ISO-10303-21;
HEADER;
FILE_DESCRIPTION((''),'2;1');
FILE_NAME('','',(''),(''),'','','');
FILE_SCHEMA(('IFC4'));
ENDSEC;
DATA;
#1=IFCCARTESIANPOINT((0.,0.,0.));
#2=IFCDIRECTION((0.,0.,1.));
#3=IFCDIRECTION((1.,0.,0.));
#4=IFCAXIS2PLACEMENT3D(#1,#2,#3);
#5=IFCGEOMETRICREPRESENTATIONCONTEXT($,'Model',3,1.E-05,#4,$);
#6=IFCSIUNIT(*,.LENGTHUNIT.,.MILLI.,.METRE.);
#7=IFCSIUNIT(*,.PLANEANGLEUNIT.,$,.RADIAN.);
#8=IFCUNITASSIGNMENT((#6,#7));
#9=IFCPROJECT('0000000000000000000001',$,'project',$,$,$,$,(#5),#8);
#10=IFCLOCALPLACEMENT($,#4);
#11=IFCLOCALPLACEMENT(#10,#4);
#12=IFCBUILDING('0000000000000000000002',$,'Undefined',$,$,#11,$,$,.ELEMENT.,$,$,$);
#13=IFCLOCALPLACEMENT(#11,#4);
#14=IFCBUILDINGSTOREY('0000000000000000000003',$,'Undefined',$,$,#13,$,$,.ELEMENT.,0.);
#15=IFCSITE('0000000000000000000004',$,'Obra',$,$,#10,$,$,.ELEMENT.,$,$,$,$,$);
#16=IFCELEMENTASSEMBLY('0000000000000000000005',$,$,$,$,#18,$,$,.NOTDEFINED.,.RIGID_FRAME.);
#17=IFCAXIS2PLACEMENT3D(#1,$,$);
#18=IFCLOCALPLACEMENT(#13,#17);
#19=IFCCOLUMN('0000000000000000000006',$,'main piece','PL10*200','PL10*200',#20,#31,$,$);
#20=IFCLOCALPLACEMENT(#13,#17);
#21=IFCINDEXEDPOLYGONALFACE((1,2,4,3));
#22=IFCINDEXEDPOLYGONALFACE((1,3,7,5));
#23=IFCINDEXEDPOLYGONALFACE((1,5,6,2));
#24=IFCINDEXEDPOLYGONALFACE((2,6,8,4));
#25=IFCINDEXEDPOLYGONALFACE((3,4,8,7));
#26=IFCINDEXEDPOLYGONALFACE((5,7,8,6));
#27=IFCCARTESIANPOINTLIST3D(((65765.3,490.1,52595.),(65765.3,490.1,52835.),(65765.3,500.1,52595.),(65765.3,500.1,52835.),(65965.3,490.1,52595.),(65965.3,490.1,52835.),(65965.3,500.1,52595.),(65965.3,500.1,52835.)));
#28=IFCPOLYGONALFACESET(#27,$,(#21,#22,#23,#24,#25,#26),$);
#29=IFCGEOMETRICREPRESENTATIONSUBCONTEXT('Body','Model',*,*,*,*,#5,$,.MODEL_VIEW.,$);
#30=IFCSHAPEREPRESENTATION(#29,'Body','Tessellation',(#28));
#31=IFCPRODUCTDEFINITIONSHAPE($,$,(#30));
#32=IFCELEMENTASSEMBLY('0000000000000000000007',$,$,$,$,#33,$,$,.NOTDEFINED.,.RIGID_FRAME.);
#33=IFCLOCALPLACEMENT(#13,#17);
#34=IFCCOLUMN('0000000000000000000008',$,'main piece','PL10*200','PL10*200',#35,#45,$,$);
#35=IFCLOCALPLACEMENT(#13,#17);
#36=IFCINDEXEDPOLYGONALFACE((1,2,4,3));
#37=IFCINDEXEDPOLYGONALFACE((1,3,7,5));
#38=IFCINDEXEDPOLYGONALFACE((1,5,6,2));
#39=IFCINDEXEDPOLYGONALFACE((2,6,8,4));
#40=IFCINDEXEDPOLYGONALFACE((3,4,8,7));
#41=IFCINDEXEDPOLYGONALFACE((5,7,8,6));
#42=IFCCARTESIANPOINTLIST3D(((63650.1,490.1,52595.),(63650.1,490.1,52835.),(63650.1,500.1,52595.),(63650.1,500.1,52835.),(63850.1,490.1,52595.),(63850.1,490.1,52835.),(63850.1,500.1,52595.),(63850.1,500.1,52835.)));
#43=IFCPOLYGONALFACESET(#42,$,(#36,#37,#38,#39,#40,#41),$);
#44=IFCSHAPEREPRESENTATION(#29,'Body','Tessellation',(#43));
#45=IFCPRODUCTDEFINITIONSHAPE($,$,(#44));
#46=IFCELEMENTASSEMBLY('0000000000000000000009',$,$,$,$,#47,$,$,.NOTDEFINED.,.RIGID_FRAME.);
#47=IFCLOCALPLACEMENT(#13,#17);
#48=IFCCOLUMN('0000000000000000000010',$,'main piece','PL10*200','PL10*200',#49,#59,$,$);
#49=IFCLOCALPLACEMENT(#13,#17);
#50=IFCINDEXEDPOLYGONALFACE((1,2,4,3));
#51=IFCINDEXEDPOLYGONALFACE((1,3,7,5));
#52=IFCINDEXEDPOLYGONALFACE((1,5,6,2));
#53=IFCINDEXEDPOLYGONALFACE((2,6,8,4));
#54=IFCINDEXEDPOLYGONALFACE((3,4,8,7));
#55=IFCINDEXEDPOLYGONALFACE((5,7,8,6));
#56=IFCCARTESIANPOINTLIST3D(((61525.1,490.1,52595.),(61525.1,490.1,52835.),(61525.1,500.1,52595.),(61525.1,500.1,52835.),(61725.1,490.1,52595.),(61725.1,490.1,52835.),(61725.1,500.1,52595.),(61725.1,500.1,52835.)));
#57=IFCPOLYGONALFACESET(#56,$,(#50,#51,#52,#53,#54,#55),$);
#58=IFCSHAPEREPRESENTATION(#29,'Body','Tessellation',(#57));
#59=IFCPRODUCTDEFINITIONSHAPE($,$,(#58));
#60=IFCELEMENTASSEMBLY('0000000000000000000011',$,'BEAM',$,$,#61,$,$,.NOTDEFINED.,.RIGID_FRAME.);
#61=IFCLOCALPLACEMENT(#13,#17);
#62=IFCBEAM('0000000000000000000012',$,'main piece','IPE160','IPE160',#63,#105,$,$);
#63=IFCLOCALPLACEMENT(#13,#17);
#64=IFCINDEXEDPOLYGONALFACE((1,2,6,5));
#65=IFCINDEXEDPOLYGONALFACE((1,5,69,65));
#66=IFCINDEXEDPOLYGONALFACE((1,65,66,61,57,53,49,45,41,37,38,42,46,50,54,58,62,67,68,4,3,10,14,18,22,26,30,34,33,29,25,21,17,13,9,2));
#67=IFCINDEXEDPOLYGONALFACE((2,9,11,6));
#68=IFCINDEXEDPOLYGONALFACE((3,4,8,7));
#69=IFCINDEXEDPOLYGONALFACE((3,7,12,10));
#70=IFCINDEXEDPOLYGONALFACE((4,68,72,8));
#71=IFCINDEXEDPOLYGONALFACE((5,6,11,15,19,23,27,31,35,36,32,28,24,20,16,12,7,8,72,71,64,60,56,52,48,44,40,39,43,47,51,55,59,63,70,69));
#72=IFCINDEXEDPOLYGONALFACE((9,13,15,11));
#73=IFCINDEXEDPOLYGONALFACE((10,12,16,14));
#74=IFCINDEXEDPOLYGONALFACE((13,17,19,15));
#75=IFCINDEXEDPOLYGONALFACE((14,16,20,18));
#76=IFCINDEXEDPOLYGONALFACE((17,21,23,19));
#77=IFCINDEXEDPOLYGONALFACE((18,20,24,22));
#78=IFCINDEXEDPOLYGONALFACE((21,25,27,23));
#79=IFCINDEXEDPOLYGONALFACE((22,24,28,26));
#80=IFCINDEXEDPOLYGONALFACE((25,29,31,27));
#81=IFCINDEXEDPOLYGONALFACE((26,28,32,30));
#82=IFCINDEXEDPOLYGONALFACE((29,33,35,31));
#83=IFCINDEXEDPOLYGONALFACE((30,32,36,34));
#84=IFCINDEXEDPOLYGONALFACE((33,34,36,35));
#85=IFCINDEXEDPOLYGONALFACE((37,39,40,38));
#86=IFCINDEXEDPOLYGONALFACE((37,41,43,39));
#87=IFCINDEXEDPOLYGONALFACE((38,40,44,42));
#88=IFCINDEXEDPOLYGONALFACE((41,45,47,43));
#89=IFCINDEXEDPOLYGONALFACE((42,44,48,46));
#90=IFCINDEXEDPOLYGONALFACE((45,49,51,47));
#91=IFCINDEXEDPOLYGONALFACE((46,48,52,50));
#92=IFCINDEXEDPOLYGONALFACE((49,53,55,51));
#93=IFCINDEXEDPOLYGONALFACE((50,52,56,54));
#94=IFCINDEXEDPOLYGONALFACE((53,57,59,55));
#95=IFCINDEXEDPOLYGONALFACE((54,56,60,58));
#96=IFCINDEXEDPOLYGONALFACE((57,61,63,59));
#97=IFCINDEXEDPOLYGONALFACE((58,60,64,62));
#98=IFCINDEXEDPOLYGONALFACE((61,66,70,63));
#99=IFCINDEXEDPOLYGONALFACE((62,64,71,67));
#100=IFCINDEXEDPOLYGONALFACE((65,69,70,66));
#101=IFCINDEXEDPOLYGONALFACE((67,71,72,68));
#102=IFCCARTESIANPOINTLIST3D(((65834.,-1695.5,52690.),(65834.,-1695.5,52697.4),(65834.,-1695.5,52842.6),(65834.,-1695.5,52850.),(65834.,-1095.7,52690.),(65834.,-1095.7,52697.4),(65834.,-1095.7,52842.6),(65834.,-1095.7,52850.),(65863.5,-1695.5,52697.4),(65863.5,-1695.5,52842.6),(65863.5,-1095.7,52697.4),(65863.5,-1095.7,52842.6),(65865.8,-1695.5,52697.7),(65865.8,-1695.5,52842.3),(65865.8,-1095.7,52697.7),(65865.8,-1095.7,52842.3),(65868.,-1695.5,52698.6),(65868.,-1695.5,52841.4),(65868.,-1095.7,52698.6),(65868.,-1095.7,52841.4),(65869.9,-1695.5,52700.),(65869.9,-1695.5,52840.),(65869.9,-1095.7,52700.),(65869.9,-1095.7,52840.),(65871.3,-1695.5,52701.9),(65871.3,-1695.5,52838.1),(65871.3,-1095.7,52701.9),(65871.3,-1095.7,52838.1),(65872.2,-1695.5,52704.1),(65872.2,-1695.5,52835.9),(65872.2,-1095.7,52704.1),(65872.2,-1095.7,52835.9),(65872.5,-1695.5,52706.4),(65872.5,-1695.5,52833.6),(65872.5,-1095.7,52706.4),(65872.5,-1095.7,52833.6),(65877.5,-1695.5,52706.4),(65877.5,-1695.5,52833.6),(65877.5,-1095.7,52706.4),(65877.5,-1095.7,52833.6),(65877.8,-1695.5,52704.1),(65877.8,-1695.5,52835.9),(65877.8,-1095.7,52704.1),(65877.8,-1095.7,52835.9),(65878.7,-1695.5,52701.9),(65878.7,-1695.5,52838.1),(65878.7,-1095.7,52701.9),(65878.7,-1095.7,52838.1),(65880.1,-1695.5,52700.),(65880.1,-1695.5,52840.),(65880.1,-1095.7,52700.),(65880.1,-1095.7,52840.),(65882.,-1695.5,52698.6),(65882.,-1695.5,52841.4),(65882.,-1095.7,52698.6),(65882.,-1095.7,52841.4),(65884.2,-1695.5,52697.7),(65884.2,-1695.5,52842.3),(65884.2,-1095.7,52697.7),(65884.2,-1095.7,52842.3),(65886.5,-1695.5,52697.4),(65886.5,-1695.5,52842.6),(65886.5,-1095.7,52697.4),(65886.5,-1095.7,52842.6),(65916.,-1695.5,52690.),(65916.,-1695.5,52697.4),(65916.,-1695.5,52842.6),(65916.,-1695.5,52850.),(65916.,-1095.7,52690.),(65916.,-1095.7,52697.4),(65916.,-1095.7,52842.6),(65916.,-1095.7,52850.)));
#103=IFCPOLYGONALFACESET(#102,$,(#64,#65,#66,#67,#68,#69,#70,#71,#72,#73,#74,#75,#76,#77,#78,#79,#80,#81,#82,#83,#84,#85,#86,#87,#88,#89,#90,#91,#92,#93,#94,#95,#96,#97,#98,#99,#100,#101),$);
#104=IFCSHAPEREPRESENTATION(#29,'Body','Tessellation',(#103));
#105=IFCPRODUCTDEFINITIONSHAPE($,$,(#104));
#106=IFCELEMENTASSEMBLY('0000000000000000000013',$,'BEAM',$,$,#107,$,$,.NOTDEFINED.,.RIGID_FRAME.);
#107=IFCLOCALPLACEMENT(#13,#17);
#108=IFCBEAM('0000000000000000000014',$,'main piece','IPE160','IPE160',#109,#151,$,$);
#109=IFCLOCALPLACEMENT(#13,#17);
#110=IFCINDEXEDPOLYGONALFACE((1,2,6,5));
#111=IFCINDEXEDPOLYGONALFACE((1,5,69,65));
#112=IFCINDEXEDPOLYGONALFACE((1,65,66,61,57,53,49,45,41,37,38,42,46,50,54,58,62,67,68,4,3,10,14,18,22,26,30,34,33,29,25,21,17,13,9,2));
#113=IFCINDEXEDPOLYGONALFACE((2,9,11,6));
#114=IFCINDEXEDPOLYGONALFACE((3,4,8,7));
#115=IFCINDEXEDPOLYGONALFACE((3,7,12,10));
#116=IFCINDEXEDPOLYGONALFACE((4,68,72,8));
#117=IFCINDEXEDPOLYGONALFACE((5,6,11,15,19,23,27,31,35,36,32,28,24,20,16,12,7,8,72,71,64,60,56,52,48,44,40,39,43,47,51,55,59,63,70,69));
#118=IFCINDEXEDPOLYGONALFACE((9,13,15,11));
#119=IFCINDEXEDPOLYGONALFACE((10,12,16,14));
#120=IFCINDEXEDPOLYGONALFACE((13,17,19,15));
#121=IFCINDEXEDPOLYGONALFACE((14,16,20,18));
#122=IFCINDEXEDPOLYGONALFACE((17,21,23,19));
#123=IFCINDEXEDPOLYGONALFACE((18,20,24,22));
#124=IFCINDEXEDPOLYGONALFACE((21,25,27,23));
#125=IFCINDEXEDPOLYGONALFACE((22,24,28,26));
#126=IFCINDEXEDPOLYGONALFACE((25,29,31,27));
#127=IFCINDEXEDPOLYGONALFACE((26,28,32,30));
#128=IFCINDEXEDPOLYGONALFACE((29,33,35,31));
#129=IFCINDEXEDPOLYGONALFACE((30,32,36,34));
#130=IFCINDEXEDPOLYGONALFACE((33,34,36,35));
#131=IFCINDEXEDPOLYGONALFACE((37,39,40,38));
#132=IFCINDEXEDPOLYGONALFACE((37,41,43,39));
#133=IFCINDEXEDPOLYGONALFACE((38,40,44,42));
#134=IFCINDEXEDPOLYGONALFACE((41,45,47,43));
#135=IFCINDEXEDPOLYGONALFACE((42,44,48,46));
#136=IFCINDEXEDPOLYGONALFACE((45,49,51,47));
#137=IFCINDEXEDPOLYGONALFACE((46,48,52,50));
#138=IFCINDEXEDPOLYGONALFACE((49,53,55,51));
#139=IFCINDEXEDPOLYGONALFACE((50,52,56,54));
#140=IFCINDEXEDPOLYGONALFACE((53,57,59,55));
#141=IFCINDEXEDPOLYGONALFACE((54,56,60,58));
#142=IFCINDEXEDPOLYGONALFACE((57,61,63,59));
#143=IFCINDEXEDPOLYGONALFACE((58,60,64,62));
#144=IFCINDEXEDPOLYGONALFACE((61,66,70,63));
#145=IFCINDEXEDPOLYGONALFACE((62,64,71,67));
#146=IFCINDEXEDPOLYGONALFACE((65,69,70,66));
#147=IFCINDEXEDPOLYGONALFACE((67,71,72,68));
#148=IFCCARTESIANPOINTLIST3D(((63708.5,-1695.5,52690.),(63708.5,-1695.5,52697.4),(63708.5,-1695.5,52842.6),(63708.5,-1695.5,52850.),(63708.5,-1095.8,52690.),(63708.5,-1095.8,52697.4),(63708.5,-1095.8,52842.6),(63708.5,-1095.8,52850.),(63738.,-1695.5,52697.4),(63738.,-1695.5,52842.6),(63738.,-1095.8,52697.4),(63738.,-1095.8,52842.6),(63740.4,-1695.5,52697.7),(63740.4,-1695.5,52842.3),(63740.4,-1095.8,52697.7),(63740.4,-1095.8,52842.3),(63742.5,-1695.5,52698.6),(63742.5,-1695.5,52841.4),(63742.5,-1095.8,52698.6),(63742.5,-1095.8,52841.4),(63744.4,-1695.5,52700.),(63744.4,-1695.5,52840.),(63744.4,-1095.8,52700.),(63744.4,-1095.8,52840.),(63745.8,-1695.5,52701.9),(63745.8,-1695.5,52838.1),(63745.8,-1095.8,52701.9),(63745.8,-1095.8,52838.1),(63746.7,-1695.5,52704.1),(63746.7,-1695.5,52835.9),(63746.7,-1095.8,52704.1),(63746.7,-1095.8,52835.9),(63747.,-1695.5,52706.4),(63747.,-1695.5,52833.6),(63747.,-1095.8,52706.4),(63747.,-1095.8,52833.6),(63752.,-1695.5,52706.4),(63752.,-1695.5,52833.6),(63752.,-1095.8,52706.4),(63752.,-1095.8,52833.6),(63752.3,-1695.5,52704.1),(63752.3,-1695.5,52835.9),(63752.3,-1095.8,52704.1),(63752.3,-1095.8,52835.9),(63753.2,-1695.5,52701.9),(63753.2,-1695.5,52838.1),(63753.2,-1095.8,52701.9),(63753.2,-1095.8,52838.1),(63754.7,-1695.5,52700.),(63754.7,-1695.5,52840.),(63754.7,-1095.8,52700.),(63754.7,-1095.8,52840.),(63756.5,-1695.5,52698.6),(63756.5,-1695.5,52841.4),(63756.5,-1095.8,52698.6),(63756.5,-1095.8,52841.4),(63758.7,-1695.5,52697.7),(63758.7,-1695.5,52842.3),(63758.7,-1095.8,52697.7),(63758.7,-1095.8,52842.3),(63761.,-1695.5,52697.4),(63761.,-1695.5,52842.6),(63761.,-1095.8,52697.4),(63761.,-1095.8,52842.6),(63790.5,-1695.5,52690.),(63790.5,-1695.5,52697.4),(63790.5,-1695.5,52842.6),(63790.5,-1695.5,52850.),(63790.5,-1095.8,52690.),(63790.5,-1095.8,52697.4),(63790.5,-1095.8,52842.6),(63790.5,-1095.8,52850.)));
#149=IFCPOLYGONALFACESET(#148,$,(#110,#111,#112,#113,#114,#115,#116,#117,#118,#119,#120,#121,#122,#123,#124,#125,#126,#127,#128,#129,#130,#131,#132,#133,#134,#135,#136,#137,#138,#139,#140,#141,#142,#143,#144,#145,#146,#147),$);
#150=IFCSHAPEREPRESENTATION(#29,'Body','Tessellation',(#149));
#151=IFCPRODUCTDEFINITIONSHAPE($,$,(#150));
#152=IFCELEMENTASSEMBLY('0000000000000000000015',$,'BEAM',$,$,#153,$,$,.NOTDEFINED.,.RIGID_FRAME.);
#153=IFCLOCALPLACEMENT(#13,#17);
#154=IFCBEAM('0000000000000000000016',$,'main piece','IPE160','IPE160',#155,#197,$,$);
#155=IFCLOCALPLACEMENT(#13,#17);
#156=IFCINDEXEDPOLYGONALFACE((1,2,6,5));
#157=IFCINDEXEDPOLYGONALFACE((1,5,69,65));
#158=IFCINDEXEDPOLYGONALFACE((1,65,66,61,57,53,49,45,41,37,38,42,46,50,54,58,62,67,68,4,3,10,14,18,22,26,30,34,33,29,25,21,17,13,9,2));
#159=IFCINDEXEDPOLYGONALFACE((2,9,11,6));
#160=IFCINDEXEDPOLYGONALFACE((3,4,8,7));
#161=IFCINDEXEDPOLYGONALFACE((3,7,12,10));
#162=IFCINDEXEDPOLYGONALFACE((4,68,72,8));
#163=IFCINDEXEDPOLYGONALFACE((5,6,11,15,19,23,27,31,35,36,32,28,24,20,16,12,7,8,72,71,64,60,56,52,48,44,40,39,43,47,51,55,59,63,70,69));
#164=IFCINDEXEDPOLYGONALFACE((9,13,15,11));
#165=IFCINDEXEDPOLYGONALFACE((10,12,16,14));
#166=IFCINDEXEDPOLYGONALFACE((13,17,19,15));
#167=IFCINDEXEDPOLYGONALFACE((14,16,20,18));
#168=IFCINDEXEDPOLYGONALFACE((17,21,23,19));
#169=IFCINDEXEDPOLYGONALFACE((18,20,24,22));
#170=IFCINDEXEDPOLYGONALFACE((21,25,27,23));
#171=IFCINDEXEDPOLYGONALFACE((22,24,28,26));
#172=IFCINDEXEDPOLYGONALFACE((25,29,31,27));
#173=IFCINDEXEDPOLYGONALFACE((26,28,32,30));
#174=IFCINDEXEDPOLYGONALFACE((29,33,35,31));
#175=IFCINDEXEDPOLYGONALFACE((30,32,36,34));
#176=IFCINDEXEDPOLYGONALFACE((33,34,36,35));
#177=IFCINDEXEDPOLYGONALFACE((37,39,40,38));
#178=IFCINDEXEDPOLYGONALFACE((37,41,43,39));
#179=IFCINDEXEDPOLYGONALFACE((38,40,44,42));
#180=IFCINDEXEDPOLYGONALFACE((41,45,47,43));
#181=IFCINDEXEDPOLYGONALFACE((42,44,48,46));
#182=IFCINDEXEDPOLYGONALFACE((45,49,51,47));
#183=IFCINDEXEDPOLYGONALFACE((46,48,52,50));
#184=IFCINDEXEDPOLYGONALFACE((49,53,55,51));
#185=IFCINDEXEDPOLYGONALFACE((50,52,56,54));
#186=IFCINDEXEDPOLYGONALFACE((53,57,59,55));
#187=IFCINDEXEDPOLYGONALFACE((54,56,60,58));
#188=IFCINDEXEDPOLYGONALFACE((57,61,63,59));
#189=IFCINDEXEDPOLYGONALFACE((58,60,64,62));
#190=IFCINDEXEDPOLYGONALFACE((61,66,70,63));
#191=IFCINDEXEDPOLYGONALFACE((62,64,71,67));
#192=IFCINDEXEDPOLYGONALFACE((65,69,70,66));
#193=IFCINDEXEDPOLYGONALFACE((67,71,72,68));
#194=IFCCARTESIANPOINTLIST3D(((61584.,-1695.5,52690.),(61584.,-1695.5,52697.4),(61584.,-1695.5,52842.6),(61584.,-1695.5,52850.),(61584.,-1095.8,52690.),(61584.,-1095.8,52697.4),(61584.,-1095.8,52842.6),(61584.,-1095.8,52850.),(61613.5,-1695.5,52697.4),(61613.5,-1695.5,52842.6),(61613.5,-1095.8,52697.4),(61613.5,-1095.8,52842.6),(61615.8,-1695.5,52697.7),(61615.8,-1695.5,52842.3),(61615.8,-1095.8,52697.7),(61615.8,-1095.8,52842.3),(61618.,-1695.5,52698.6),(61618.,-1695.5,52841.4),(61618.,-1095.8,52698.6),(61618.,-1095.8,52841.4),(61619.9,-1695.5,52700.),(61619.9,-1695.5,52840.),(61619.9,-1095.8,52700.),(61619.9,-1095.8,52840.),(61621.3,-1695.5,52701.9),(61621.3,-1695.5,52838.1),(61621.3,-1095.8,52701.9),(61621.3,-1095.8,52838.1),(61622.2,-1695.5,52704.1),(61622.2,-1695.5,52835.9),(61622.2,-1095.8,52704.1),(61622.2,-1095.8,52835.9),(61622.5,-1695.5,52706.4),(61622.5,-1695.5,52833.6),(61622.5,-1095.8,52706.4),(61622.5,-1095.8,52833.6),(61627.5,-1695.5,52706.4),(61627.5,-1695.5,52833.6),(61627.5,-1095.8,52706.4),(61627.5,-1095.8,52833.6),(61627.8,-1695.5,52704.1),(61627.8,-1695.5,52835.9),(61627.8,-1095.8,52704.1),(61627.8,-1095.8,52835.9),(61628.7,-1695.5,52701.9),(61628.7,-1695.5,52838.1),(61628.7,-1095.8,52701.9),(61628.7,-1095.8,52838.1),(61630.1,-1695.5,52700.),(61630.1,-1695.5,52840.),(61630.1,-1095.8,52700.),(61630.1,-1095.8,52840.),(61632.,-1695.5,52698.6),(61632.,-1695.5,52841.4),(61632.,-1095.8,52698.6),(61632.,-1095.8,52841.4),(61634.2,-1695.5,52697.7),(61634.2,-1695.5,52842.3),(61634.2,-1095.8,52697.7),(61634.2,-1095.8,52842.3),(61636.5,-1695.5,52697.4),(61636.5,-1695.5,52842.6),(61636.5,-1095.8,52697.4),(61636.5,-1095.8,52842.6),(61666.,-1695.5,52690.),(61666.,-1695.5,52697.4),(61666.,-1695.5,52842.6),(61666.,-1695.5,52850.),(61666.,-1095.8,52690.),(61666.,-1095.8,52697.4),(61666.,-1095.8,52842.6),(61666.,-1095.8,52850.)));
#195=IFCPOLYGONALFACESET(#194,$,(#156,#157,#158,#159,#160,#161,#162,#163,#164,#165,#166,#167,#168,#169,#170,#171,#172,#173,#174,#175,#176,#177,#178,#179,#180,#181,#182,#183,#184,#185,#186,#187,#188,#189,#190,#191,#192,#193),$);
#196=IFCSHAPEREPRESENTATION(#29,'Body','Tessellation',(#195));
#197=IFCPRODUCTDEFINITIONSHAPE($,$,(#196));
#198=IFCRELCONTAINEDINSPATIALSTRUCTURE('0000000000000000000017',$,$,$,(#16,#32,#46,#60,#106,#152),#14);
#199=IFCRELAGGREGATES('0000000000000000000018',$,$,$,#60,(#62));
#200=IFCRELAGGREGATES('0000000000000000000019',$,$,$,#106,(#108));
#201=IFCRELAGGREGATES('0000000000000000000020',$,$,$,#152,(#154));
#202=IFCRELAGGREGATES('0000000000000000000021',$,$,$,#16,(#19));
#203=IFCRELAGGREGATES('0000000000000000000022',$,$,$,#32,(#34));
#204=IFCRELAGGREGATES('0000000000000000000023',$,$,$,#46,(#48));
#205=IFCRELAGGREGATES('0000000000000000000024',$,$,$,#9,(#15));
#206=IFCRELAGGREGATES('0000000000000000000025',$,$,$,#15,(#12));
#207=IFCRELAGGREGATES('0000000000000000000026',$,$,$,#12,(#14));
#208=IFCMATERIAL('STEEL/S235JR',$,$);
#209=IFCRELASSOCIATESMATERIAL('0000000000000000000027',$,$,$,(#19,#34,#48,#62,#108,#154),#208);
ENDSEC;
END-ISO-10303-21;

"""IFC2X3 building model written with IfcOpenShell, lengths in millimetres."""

from ifc_helpers import new_model, si_unit, frame, origin_with_axes, origin_2d_with_axis, place, context, subcontext, project, spatial, rectangle, i_section, extrude, material, element, aggregate, save


model = new_model("IFC2X3")

# Units and contexts
model_context = context("Model", 3, precision=1e-05, world=origin_with_axes())
body_context = subcontext(model_context, "Body", "Model", "MODEL_VIEW")
ifc_project = project(units=[si_unit("LENGTHUNIT", "METRE", prefix="MILLI"), si_unit("PLANEANGLEUNIT", "RADIAN")], contexts=[model_context])

# Site, building, storey
site_placement = place(None, origin_with_axes())
site = spatial("IfcSite", under=ifc_project, at=site_placement, Name="Obra", CompositionType="ELEMENT")
building_placement = place(site_placement, origin_with_axes())
building = spatial("IfcBuilding", under=site, at=building_placement, Name="Undefined", CompositionType="ELEMENT")
storey_placement = place(building_placement, origin_with_axes())
storey = spatial("IfcBuildingStorey", under=building, at=storey_placement, Name="Undefined", CompositionType="ELEMENT", Elevation=0.0)

# Element assemblies, columns
assembly_1_placement = place(storey_placement, origin_with_axes())
assembly_1 = element("IfcElementAssembly", 1, at=assembly_1_placement, inside=storey, AssemblyPlace="NOTDEFINED", PredefinedType="RIGID_FRAME")
ifc_material_1 = material(Name="STEEL/S235JR")
column_1_placement = place(assembly_1_placement, frame((65865.3, 495.1, 52595.0), z_axis=(0.0, 0.0, 1.0), x_axis=(1.0, 0.000002, 0.0)))
column_1 = element("IfcColumn", 2, at=column_1_placement, material=ifc_material_1, Name="main piece", Description="PL10*200", ObjectType="PL10*200", context=body_context, shape_type="SweptSolid", body=[
    extrude(rectangle(XDim=10.0, YDim=200.0, at=origin_2d_with_axis()), frame((0.0, 0.0, 240.0), z_axis=(0.0, 0.0, -1.0), x_axis=(0.0, 1.0, 0.0)), (0.0, 0.0, 1.0), 240.0),
])
assembly_2_placement = place(storey_placement, origin_with_axes())
assembly_2 = element("IfcElementAssembly", 3, at=assembly_2_placement, inside=storey, AssemblyPlace="NOTDEFINED", PredefinedType="RIGID_FRAME")
column_2_placement = place(assembly_2_placement, frame((63750.1, 495.1, 52595.0), z_axis=(0.0, 0.0, 1.0), x_axis=(1.0, 0.000002, 0.0)))
column_2 = element("IfcColumn", 4, at=column_2_placement, material=ifc_material_1, Name="main piece", Description="PL10*200", ObjectType="PL10*200", context=body_context, shape_type="SweptSolid", body=[
    extrude(rectangle(XDim=10.0, YDim=200.0, at=origin_2d_with_axis()), frame((0.0, 0.0, 240.0), z_axis=(0.0, 0.0, -1.0), x_axis=(0.0, 1.0, 0.0)), (0.0, 0.0, 1.0), 240.0),
])
assembly_3_placement = place(storey_placement, origin_with_axes())
assembly_3 = element("IfcElementAssembly", 5, at=assembly_3_placement, inside=storey, AssemblyPlace="NOTDEFINED", PredefinedType="RIGID_FRAME")
column_3_placement = place(assembly_3_placement, frame((61625.1, 495.1, 52595.0), z_axis=(0.0, 0.0, 1.0), x_axis=(1.0, 0.000002, 0.0)))
column_3 = element("IfcColumn", 6, at=column_3_placement, material=ifc_material_1, Name="main piece", Description="PL10*200", ObjectType="PL10*200", context=body_context, shape_type="SweptSolid", body=[
    extrude(rectangle(XDim=10.0, YDim=200.0, at=origin_2d_with_axis()), frame((0.0, 0.0, 240.0), z_axis=(0.0, 0.0, -1.0), x_axis=(0.0, 1.0, 0.0)), (0.0, 0.0, 1.0), 240.0),
])

# Element assemblies, beams
assembly_4_placement = place(storey_placement, origin_with_axes())
assembly_4 = element("IfcElementAssembly", 7, at=assembly_4_placement, inside=storey, Name="BEAM", AssemblyPlace="NOTDEFINED", PredefinedType="RIGID_FRAME")
beam_1_placement = place(assembly_4_placement, frame((65875.0, -1095.7, 52770.0), z_axis=(0.0, 0.0, 1.0), x_axis=(0.0, -1.0, 0.0)))
beam_1 = element("IfcBeam", 8, at=beam_1_placement, material=ifc_material_1, Name="main piece", Description="IPE160", ObjectType="IPE160", context=body_context, shape_type="SweptSolid", body=[
    extrude(i_section(OverallWidth=82.0, OverallDepth=160.0, WebThickness=5.0, FlangeThickness=7.4, FilletRadius=9.0, at=origin_2d_with_axis()), frame((599.8, 0.0, 0.0), z_axis=(-1.0, 0.0, 0.0), x_axis=(0.0, -1.0, 0.0)), (0.0, 0.0, 1.0), 599.8),
])
aggregate(assembly_4, [beam_1])
assembly_5_placement = place(storey_placement, origin_with_axes())
assembly_5 = element("IfcElementAssembly", 9, at=assembly_5_placement, inside=storey, Name="BEAM", AssemblyPlace="NOTDEFINED", PredefinedType="RIGID_FRAME")
beam_2_placement = place(assembly_5_placement, frame((63749.5, -1095.8, 52770.0), z_axis=(0.0, 0.0, 1.0), x_axis=(0.0, -1.0, 0.0)))
beam_2 = element("IfcBeam", 10, at=beam_2_placement, material=ifc_material_1, Name="main piece", Description="IPE160", ObjectType="IPE160", context=body_context, shape_type="SweptSolid", body=[
    extrude(i_section(OverallWidth=82.0, OverallDepth=160.0, WebThickness=5.0, FlangeThickness=7.4, FilletRadius=9.0, at=origin_2d_with_axis()), frame((599.7, 0.0, 0.0), z_axis=(-1.0, 0.0, 0.0), x_axis=(0.0, -1.0, 0.0)), (0.0, 0.0, 1.0), 599.7),
])
aggregate(assembly_5, [beam_2])
assembly_6_placement = place(storey_placement, origin_with_axes())
assembly_6 = element("IfcElementAssembly", 11, at=assembly_6_placement, inside=storey, Name="BEAM", AssemblyPlace="NOTDEFINED", PredefinedType="RIGID_FRAME")
beam_3_placement = place(assembly_6_placement, frame((61625.0, -1095.8, 52770.0), z_axis=(0.0, 0.0, 1.0), x_axis=(0.0, -1.0, 0.0)))
beam_3 = element("IfcBeam", 12, at=beam_3_placement, material=ifc_material_1, Name="main piece", Description="IPE160", ObjectType="IPE160", context=body_context, shape_type="SweptSolid", body=[
    extrude(i_section(OverallWidth=82.0, OverallDepth=160.0, WebThickness=5.0, FlangeThickness=7.4, FilletRadius=9.0, at=origin_2d_with_axis()), frame((599.7, 0.0, 0.0), z_axis=(-1.0, 0.0, 0.0), x_axis=(0.0, -1.0, 0.0)), (0.0, 0.0, 1.0), 599.7),
])
aggregate(assembly_6, [beam_3])

aggregate(assembly_1, [column_1])
aggregate(assembly_2, [column_2])
aggregate(assembly_3, [column_3])

save(model, "model.ifc")
